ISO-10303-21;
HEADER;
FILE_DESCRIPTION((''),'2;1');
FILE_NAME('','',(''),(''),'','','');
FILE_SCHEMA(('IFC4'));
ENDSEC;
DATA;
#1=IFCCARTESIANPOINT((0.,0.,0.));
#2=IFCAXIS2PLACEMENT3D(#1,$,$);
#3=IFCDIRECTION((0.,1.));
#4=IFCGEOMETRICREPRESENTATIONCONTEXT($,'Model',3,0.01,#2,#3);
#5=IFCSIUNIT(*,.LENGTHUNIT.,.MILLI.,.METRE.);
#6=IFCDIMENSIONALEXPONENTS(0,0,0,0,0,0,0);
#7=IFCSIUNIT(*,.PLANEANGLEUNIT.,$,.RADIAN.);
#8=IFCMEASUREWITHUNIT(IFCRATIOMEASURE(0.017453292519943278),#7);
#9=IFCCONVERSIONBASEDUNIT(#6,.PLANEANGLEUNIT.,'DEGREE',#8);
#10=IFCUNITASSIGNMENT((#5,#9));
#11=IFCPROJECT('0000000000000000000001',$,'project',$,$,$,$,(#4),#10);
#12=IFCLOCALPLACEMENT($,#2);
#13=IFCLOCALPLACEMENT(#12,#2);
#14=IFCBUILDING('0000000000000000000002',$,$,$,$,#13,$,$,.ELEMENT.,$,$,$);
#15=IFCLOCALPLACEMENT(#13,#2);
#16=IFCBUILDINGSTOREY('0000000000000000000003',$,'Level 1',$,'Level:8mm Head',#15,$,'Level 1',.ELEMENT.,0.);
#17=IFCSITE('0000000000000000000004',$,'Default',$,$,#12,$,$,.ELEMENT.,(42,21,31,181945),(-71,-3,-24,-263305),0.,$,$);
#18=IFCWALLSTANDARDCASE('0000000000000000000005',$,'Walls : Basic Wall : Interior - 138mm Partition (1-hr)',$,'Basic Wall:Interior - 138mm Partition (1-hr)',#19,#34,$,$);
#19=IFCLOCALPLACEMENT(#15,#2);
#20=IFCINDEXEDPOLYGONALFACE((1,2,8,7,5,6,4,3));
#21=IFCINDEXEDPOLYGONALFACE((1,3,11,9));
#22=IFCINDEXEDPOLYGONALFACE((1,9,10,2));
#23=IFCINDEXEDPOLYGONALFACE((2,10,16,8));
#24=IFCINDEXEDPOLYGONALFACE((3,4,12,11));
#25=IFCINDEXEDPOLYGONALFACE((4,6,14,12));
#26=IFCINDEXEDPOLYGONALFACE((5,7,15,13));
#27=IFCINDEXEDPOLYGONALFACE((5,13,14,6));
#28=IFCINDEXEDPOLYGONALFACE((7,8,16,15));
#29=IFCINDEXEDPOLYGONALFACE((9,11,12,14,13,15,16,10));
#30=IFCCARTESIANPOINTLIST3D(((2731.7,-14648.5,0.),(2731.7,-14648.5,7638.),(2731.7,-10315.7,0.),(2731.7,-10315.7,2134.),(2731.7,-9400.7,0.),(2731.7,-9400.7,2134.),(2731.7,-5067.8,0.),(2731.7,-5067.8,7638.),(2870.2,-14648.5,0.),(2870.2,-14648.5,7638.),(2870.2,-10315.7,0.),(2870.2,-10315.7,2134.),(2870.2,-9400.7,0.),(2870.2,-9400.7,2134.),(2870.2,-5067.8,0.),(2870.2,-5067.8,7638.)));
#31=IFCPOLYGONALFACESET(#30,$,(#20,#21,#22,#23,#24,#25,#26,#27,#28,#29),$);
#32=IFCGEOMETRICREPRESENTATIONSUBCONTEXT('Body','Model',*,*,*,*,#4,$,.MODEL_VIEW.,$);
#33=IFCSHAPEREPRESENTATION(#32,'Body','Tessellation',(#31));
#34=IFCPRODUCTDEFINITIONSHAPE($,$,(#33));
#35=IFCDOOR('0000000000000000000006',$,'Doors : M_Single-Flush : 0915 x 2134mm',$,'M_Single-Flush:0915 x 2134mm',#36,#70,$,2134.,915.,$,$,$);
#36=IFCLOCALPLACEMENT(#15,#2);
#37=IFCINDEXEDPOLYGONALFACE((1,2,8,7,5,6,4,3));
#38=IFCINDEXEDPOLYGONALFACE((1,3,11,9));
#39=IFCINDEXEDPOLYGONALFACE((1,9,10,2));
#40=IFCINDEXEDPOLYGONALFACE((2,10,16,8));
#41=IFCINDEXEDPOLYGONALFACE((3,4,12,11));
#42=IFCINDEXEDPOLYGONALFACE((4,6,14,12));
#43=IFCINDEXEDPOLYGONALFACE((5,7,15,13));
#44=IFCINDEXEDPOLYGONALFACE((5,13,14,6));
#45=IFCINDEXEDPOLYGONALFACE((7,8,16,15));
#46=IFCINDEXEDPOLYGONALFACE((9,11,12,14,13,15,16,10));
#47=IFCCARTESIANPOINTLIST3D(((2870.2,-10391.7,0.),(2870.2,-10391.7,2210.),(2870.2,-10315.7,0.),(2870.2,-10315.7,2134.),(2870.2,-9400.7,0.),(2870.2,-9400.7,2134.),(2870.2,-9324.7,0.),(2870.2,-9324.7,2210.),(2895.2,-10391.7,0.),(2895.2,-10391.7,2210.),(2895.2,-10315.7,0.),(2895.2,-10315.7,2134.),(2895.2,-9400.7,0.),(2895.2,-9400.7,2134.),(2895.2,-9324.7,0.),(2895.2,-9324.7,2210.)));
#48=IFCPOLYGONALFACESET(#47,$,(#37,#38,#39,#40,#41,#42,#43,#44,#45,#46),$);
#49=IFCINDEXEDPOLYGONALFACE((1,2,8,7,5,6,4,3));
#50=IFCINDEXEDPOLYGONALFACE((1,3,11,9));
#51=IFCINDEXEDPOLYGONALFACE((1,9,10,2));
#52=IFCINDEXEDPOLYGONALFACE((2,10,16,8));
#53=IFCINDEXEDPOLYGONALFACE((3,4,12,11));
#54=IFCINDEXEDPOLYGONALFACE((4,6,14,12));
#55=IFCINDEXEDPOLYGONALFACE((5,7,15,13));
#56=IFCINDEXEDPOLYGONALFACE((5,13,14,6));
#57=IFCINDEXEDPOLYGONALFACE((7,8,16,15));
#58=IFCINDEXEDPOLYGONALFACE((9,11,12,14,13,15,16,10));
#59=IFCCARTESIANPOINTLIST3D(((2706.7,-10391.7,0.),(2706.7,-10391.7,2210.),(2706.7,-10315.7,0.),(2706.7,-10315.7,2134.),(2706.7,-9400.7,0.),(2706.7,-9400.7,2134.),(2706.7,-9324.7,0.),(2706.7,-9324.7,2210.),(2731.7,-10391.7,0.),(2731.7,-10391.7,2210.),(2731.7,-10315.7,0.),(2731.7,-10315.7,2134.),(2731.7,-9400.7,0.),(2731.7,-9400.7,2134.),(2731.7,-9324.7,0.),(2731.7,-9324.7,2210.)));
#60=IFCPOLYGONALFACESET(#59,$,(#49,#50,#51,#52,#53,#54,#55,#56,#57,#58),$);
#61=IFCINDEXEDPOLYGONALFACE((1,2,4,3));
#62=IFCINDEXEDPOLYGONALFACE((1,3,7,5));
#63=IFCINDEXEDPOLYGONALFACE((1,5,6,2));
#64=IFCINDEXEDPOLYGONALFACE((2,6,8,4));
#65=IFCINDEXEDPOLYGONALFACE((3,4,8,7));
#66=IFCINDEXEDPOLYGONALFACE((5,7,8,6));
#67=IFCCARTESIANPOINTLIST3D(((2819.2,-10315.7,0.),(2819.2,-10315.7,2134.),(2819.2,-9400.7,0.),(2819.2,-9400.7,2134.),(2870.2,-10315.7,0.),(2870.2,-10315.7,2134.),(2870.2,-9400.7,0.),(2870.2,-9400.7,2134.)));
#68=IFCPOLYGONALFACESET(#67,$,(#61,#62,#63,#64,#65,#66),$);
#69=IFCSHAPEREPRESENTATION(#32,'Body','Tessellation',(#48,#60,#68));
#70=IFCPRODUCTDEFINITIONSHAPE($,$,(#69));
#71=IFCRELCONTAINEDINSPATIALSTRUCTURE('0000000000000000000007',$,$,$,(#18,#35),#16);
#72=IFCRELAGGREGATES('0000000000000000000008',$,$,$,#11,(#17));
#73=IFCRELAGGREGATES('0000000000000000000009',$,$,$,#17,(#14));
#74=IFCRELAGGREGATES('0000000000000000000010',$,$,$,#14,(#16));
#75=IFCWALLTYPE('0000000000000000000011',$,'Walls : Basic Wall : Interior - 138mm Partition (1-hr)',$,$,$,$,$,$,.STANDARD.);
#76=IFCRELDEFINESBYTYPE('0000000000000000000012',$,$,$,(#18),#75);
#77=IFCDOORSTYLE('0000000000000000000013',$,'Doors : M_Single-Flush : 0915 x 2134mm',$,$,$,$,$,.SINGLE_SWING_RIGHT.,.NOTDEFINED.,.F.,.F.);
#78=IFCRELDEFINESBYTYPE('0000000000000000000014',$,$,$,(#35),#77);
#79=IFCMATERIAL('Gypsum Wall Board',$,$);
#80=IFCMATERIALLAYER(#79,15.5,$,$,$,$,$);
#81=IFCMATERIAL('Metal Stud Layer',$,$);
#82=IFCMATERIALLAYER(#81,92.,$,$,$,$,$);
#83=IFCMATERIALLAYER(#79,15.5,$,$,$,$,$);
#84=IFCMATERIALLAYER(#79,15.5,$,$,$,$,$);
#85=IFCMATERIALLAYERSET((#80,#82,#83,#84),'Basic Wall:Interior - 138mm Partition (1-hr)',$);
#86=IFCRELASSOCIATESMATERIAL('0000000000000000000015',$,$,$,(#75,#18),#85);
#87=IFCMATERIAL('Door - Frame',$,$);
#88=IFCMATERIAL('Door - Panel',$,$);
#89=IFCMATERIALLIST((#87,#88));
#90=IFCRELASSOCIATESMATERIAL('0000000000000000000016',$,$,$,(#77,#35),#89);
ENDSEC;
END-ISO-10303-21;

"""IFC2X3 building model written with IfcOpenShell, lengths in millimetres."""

from ifc_helpers import new_model, entity, si_unit, converted_unit, direction, frame, frame_2d, origin, place, context, subcontext, project, spatial, polyline, rectangle, outline, extrude, clip, bounded_halfspace, source, transform, mapped, material, material_list, layer, layer_set, layer_usage, type_object, type_shapes, element, fill, save


model = new_model("IFC2X3")

# Units and contexts
model_context = context("Model", 3, precision=0.01, world=origin(), true_north=direction((0.0, 1.0)))
body_context = subcontext(model_context, "Body", "Model", "MODEL_VIEW")
ifc_project = project(units=[si_unit("LENGTHUNIT", "METRE", prefix="MILLI"), converted_unit("PLANEANGLEUNIT", "DEGREE", entity("IfcRatioMeasure", 0.017453292519943278), si_unit("PLANEANGLEUNIT", "RADIAN"), dimensions=[0, 0, 0, 0, 0, 0, 0])], contexts=[model_context])

# Site, building, storey
site_placement = place(None, origin())
site = spatial("IfcSite", under=ifc_project, at=site_placement, Name="Default", CompositionType="ELEMENT", RefLatitude=(42, 21, 31, 181945), RefLongitude=(-71, -3, -24, -263305), RefElevation=0.0)
building_placement = place(site_placement, origin())
building = spatial("IfcBuilding", under=site, at=building_placement, CompositionType="ELEMENT")
storey_placement = place(building_placement, origin())
storey = spatial("IfcBuildingStorey", under=building, at=storey_placement, Name="Level 1", ObjectType="Level:8mm Head", LongName="Level 1", CompositionType="ELEMENT", Elevation=0.0)

# Shared definitions
ifc_material_1 = material(Name="Metal Stud Layer")
ifc_material_2 = material(Name="Gypsum Wall Board")
ifc_layer_1 = layer(ifc_material_2, 15.5)
ifc_layer_2 = layer(ifc_material_1, 92.0)
ifc_layer_3 = layer(ifc_material_2, 15.5)
ifc_layer_4 = layer(ifc_material_2, 15.5)
ifc_layer_set_1 = layer_set([ifc_layer_1, ifc_layer_2, ifc_layer_3, ifc_layer_4], Name="Basic Wall:Interior - 138mm Partition (1-hr)")
wall_type_1 = type_object("IfcWallType", Name="Walls : Basic Wall : Interior - 138mm Partition (1-hr)", PredefinedType="STANDARD", material=ifc_layer_set_1)

# Wall, opening, door
ifc_layer_usage_1 = layer_usage(ifc_layer_set_1, "AXIS2", "NEGATIVE", 69.2)
ifc_material_3 = material(Name="Door - Frame")
ifc_material_4 = material(Name="Door - Panel")
ifc_material_list = material_list([ifc_material_3, ifc_material_4])
door_style_1 = type_object("IfcDoorStyle", Name="Doors : M_Single-Flush : 0915 x 2134mm", ConstructionType="NOTDEFINED", OperationType="SINGLE_SWING_RIGHT", ParameterTakesPrecedence=False, Sizeable=False, material=ifc_material_list)
shared_shape_1 = source(origin(), body_context, "Body", "SweptSolid", [
    extrude(outline(polyline([(-533.5, -1124.0), (533.5, -1124.0), (533.5, 1086.0), (457.5, 1086.0), (457.5, -1048.0), (-457.5, -1048.0), (-457.5, 1086.0), (-533.5, 1086.0), (-533.5, -1124.0)])), frame((457.5, 138.5, 1086.0), z_axis=(0.0, 1.0, 0.0), x_axis=(1.0, 0.0, 0.0)), (0.0, 0.0, 1.0), 25.0),
    extrude(outline(polyline([(-1124.0, -533.5), (1086.0, -533.5), (1086.0, -457.5), (-1048.0, -457.5), (-1048.0, 457.5), (1086.0, 457.5), (1086.0, 533.5), (-1124.0, 533.5), (-1124.0, -533.5)])), frame((457.5, -25.0, 1086.0), z_axis=(0.0, 1.0, 0.0), x_axis=(0.0, 0.0, -1.0)), (0.0, 0.0, 1.0), 25.0),
    extrude(rectangle(XDim=51.0, YDim=915.0, at=frame_2d((0.0, 0.0), x_axis=(1.0, 0.0))), frame((457.5, 113.0, 0.0), z_axis=(0.0, 0.0, 1.0), x_axis=(0.0, 1.0, 0.0)), (0.0, 0.0, 1.0), 2134.0),
])
type_shapes(door_style_1, [shared_shape_1])
wall_1_placement = place(storey_placement, frame((2800.9, -5067.8, 0.0), z_axis=(0.0, 0.0, 1.0), x_axis=(0.0, -1.0, 0.0)))
wall_1 = element("IfcWallStandardCase", 1, at=wall_1_placement, inside=storey, type_object=wall_type_1, material=ifc_layer_usage_1, Name="Walls : Basic Wall : Interior - 138mm Partition (1-hr)", ObjectType="Basic Wall:Interior - 138mm Partition (1-hr)", context=body_context, shape_type="Clipping", body=[
    clip(extrude(rectangle(XDim=9580.8, YDim=138.5, at=frame_2d((4790.4, 0.0), x_axis=(1.0, 0.0))), origin(), (0.0, 0.0, 1.0), 7638.0), bounded_halfspace(frame((0.0, -69.2, 7638.0), z_axis=(0.0, 0.0, -1.0), x_axis=(1.0, 0.0, 0.0)), True, frame((0.0, -69.2, 7638.0)), polyline([(0.0, 0.0), (2920212.6, 0.0), (2920212.6, 42214.8), (0.0, 42214.8), (0.0, 0.0)]))),
])
opening_1_placement = place(wall_1_placement, frame((4332.9, -69.3, 0.0)))
opening_1 = element("IfcOpeningElement", 2, at=opening_1_placement, cuts=wall_1, ObjectType="Opening", context=body_context, shape_type="SweptSolid", body=[
    extrude(rectangle(XDim=915.0, YDim=2134.0, at=frame_2d((1067.0, 457.5), x_axis=(0.0, 1.0))), frame((0.0, 0.0, 0.0), z_axis=(0.0, 1.0, 0.0), x_axis=(0.0, 0.0, 1.0)), (0.0, 0.0, 1.0), 138.5),
])
door_1_placement = place(opening_1_placement, origin())
door_1 = element("IfcDoor", 3, at=door_1_placement, inside=storey, type_object=door_style_1, material=ifc_material_list, Name="Doors : M_Single-Flush : 0915 x 2134mm", ObjectType="M_Single-Flush:0915 x 2134mm", OverallHeight=2134.0, OverallWidth=915.0, context=body_context, shape_type="MappedRepresentation", body=[
    mapped(shared_shape_1, transform((0.0, 0.0, 0.0), scale=1.0)),
])
fill(opening_1, door_1)

save(model, "model.ifc")
